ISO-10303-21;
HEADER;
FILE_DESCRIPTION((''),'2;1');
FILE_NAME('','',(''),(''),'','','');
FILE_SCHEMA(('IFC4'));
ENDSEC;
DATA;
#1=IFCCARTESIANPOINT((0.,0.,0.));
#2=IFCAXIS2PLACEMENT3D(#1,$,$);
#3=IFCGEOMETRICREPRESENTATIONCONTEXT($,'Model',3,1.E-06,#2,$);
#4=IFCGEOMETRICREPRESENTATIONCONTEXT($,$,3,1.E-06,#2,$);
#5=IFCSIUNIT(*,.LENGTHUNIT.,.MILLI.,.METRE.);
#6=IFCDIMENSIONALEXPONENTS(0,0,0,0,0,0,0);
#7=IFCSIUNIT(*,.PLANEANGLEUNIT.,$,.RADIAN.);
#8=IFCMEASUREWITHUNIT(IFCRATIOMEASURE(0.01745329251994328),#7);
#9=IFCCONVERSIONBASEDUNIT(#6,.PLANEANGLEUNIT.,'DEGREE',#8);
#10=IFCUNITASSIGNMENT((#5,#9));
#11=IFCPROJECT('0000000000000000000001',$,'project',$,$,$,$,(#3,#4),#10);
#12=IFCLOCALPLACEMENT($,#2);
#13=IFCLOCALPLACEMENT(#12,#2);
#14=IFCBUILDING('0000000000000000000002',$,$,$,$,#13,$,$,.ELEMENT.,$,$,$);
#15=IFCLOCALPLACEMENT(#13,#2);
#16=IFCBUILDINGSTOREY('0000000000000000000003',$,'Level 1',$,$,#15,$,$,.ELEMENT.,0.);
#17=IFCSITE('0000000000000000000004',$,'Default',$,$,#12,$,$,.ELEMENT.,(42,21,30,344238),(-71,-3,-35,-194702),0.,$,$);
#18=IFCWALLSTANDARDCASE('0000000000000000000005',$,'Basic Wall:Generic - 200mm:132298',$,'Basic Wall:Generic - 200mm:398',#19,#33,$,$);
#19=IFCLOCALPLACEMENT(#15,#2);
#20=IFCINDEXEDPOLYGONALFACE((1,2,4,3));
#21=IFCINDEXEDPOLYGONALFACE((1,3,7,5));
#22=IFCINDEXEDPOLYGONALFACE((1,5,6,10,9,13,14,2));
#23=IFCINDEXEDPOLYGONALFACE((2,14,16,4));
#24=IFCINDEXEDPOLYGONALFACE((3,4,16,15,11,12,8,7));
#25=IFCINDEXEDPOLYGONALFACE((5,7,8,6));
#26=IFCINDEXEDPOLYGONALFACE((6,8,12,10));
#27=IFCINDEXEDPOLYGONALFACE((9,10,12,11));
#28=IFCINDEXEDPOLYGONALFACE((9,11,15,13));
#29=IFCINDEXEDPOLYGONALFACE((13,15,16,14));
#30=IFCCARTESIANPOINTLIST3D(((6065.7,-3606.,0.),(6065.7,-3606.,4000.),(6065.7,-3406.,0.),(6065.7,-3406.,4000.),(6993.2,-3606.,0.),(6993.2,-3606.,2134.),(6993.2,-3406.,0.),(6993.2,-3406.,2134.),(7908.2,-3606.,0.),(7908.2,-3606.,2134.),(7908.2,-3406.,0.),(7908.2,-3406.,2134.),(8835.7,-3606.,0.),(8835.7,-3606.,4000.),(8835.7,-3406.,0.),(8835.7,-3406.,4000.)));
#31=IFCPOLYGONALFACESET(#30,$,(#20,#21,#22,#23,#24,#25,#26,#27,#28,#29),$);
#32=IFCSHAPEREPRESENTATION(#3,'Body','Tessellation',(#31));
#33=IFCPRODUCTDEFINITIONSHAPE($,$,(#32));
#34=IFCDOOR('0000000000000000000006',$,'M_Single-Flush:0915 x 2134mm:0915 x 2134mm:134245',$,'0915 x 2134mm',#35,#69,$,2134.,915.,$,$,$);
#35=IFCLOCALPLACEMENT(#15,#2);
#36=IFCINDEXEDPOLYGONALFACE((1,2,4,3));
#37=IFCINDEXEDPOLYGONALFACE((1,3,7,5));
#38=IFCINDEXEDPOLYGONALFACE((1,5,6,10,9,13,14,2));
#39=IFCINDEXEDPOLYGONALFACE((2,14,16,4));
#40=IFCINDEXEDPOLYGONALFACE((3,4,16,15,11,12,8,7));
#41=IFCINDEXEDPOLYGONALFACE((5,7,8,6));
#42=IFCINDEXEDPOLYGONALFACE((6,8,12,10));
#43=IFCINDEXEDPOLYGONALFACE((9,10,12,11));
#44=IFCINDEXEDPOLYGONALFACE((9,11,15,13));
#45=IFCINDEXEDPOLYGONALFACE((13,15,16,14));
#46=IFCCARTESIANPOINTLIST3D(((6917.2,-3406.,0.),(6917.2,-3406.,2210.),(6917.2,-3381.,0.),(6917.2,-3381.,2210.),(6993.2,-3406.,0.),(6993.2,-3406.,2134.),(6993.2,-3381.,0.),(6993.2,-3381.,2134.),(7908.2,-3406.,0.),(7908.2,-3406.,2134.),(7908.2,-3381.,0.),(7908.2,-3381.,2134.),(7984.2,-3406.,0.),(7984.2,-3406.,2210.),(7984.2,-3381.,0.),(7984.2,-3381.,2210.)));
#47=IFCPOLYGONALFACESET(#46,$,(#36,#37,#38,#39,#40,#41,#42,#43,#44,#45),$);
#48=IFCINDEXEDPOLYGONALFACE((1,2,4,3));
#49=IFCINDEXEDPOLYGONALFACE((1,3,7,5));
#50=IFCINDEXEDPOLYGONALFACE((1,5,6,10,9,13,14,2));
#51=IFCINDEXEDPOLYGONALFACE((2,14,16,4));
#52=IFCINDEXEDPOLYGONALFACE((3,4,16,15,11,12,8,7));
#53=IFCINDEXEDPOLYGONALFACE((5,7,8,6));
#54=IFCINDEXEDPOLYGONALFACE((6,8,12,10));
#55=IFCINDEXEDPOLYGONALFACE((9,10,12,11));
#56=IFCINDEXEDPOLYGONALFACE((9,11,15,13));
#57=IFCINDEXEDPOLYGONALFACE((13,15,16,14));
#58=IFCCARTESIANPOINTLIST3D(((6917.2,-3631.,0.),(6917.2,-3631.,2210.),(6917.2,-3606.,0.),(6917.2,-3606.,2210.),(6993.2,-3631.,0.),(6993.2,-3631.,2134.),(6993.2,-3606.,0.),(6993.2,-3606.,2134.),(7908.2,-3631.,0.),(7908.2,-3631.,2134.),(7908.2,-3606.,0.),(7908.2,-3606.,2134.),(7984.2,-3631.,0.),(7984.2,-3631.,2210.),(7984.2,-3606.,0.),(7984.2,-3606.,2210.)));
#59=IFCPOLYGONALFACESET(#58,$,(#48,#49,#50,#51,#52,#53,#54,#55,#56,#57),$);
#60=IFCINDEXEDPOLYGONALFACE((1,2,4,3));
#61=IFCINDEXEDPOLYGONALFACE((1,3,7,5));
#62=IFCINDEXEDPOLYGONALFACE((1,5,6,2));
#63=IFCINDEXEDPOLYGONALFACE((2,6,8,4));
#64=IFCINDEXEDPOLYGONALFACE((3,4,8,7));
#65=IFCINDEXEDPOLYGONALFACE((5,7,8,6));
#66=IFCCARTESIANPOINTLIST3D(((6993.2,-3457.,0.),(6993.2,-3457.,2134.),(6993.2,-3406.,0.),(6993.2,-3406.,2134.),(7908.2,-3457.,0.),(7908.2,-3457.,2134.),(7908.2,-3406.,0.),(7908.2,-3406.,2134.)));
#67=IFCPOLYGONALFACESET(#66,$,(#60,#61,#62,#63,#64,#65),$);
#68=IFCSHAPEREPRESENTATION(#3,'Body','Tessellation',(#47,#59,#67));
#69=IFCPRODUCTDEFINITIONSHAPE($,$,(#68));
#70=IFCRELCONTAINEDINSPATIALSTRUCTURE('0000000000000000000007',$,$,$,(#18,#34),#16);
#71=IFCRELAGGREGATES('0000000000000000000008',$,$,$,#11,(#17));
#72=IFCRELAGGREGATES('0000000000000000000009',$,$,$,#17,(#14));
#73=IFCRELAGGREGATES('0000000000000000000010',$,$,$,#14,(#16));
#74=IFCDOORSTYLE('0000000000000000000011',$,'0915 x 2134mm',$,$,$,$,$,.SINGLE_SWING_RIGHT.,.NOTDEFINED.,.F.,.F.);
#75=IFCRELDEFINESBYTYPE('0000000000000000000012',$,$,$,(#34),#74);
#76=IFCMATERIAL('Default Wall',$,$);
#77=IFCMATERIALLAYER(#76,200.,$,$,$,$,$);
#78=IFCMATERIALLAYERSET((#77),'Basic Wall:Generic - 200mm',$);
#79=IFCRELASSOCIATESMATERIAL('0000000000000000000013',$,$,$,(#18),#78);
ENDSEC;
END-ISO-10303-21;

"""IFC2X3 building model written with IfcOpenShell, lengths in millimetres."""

from ifc_helpers import new_model, entity, si_unit, converted_unit, frame, frame_2d, origin, origin_2d_with_axis, place, context, project, spatial, polyline, rectangle, outline, extrude, source, transform, mapped, material, layer, layer_set, layer_usage, type_object, type_shapes, element, fill, save


model = new_model("IFC2X3")

# Units and contexts
model_context = context("Model", 3, precision=1e-06, world=origin())
context_of_model = context(None, 3, precision=1e-06, world=origin())
ifc_project = project(units=[si_unit("LENGTHUNIT", "METRE", prefix="MILLI"), converted_unit("PLANEANGLEUNIT", "DEGREE", entity("IfcRatioMeasure", 0.01745329251994328), si_unit("PLANEANGLEUNIT", "RADIAN"), dimensions=[0, 0, 0, 0, 0, 0, 0])], contexts=[model_context, context_of_model])

# Site, building, storey
site_placement = place(None, origin())
site = spatial("IfcSite", under=ifc_project, at=site_placement, Name="Default", CompositionType="ELEMENT", RefLatitude=(42, 21, 30, 344238), RefLongitude=(-71, -3, -35, -194702), RefElevation=0.0)
building_placement = place(site_placement, origin())
building = spatial("IfcBuilding", under=site, at=building_placement, CompositionType="ELEMENT")
storey_placement = place(building_placement, origin())
storey = spatial("IfcBuildingStorey", under=building, at=storey_placement, Name="Level 1", CompositionType="ELEMENT", Elevation=0.0)

# Shared definitions
ifc_material_1 = material(Name="Default Wall")
ifc_layer_1 = layer(ifc_material_1, 200.0)
ifc_layer_set_1 = layer_set([ifc_layer_1], Name="Basic Wall:Generic - 200mm")

# Wall, opening, door
ifc_layer_usage_1 = layer_usage(ifc_layer_set_1, "AXIS2", "NEGATIVE", 100.0)
wall_1_placement = place(storey_placement, frame((8835.7, -3506.0, 0.0), z_axis=(0.0, 0.0, 1.0), x_axis=(-1.0, 0.0, 0.0)))
wall_1 = element("IfcWallStandardCase", 1, at=wall_1_placement, inside=storey, material=ifc_layer_usage_1, Name="Basic Wall:Generic - 200mm:132298", ObjectType="Basic Wall:Generic - 200mm:398", context=model_context, shape_type="SweptSolid", body=[
    extrude(rectangle(XDim=2770.0, YDim=200.0, at=frame_2d((1385.0, 0.0), x_axis=(-1.0, 0.0))), origin(), (0.0, 0.0, 1.0), 4000.0),
])
opening_1_placement = place(wall_1_placement, frame((1842.5, 100.0, 0.0)))
opening_1 = element("IfcOpeningElement", 2, at=opening_1_placement, cuts=wall_1, ObjectType="Opening", context=model_context, shape_type="SweptSolid", body=[
    extrude(rectangle(XDim=915.0, YDim=2134.0, at=frame_2d((1067.0, 457.5), x_axis=(0.0, 1.0))), frame((0.0, 0.0, 0.0), z_axis=(0.0, -1.0, 0.0), x_axis=(0.0, 0.0, 1.0)), (0.0, 0.0, 1.0), 200.0),
])
door_style_1 = type_object("IfcDoorStyle", Name="0915 x 2134mm", ConstructionType="NOTDEFINED", OperationType="SINGLE_SWING_RIGHT", ParameterTakesPrecedence=False, Sizeable=False)
shared_shape_1 = source(origin(), model_context, "Body", "SweptSolid", [
    extrude(outline(polyline([(-533.5, -1124.0), (533.5, -1124.0), (533.5, 1086.0), (457.5, 1086.0), (457.5, -1048.0), (-457.5, -1048.0), (-457.5, 1086.0), (-533.5, 1086.0), (-533.5, -1124.0)])), frame((457.5, 200.0, 1086.0), z_axis=(0.0, 1.0, 0.0), x_axis=(1.0, 0.0, 0.0)), (0.0, 0.0, 1.0), 25.0),
    extrude(outline(polyline([(-1124.0, -533.5), (1086.0, -533.5), (1086.0, -457.5), (-1048.0, -457.5), (-1048.0, 457.5), (1086.0, 457.5), (1086.0, 533.5), (-1124.0, 533.5), (-1124.0, -533.5)])), frame((457.5, -25.0, 1086.0), z_axis=(0.0, 1.0, 0.0), x_axis=(0.0, 0.0, -1.0)), (0.0, 0.0, 1.0), 25.0),
    extrude(rectangle(XDim=51.0, YDim=915.0, at=origin_2d_with_axis()), frame((457.5, 174.5, 0.0), z_axis=(0.0, 0.0, 1.0), x_axis=(0.0, 1.0, 0.0)), (0.0, 0.0, 1.0), 2134.0),
])
type_shapes(door_style_1, [shared_shape_1])
door_1_placement = place(opening_1_placement, frame((0.0, 0.0, 0.0), z_axis=(0.0, 0.0, 1.0), x_axis=(-1.0, 0.0, 0.0)))
door_1 = element("IfcDoor", 3, at=door_1_placement, inside=storey, type_object=door_style_1, Name="M_Single-Flush:0915 x 2134mm:0915 x 2134mm:134245", ObjectType="0915 x 2134mm", OverallHeight=2134.0, OverallWidth=915.0, context=model_context, shape_type="MappedRepresentation", body=[
    mapped(shared_shape_1, transform((0.0, 0.0, 0.0), scale=1.0)),
])
fill(opening_1, door_1)

save(model, "model.ifc")
